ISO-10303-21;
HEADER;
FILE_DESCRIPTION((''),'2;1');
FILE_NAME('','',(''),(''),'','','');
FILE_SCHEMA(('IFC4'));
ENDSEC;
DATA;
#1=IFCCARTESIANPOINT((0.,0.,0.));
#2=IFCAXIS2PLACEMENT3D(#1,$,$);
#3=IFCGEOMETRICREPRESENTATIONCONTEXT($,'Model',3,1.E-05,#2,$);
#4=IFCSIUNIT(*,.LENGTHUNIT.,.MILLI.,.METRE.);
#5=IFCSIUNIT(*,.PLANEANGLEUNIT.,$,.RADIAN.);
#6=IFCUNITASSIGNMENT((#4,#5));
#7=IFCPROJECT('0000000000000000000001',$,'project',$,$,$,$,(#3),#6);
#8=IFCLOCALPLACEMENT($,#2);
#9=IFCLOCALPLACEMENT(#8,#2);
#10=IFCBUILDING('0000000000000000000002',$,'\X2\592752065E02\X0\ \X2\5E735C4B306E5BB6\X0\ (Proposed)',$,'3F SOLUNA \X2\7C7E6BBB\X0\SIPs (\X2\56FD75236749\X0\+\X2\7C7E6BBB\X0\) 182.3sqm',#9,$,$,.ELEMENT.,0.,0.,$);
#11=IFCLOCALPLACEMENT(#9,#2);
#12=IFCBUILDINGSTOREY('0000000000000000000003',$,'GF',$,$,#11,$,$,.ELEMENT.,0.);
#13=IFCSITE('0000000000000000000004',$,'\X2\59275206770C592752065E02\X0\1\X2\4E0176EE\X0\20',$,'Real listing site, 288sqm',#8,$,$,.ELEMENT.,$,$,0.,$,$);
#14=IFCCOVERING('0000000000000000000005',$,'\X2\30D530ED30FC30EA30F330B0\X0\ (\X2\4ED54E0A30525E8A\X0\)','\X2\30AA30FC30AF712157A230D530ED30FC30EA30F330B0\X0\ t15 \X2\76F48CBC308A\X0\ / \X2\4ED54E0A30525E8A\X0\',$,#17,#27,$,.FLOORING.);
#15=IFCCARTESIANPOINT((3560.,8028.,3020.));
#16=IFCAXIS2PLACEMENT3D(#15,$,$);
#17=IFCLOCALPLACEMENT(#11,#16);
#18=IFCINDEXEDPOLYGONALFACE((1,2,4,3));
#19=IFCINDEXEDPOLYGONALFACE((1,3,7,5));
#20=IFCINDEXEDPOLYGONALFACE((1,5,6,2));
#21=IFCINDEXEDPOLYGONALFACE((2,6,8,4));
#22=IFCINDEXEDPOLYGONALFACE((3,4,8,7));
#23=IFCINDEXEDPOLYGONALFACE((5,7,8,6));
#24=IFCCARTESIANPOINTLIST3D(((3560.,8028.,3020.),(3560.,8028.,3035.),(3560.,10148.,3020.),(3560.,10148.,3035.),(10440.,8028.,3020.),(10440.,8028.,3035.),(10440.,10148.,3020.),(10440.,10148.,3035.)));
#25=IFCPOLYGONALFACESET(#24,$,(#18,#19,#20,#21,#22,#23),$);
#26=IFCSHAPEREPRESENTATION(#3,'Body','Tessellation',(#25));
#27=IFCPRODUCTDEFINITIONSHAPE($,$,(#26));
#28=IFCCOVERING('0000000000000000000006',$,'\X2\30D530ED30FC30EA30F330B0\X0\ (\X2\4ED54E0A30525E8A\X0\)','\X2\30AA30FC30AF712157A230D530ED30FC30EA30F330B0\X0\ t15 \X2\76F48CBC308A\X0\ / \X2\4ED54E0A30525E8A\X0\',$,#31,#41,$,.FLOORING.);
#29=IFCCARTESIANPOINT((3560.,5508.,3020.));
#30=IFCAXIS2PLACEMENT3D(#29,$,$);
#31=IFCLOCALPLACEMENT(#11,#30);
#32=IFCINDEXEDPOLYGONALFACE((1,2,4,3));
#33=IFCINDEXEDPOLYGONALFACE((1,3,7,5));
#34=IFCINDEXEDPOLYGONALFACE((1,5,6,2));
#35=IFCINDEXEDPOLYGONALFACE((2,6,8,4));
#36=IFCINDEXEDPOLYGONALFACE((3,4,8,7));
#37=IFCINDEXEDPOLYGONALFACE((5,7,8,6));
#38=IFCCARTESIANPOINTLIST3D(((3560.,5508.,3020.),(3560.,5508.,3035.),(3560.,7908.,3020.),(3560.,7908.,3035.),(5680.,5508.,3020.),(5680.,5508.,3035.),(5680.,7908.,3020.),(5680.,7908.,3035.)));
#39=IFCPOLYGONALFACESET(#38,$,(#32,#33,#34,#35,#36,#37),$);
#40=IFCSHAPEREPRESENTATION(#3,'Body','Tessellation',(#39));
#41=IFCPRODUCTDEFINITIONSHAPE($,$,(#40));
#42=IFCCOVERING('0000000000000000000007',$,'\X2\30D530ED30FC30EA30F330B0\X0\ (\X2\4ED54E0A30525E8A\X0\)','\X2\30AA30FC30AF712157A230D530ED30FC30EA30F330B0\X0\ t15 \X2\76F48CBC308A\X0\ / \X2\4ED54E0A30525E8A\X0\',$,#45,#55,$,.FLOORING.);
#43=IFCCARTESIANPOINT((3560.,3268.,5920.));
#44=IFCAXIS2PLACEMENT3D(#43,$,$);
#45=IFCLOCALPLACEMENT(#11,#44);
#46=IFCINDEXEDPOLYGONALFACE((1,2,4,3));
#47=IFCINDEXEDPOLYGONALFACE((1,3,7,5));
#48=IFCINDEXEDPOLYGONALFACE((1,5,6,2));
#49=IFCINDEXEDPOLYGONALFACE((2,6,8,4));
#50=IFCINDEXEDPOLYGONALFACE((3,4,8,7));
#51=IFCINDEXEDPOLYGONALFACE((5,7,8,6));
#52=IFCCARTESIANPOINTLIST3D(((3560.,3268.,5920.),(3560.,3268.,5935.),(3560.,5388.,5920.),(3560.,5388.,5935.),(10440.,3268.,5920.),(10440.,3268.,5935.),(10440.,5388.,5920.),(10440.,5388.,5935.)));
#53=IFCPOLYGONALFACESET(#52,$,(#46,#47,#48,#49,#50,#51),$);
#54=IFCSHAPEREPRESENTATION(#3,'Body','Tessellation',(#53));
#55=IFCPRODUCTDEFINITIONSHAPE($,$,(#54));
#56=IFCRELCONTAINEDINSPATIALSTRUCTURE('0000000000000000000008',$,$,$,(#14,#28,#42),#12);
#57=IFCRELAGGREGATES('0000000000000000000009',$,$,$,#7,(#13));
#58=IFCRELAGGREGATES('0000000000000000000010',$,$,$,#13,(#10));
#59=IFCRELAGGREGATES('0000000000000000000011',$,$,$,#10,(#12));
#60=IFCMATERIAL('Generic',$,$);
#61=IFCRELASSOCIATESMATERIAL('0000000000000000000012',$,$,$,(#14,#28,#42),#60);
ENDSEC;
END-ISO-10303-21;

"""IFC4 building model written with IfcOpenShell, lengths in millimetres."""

from ifc_helpers import new_model, si_unit, frame, frame_2d, origin, place, context, project, spatial, rectangle, extrude, material, element, save


model = new_model("IFC4")

# Units and contexts
model_context = context("Model", 3, precision=1e-05, world=origin())
ifc_project = project(units=[si_unit("LENGTHUNIT", "METRE", prefix="MILLI"), si_unit("PLANEANGLEUNIT", "RADIAN")], contexts=[model_context])

# Site, building, storey
site_placement = place(None, origin())
site = spatial("IfcSite", under=ifc_project, at=site_placement, Name="大分県大分市1丁目20", ObjectType="Real listing site, 288sqm", CompositionType="ELEMENT", RefElevation=0.0)
building_placement = place(site_placement, origin())
building = spatial("IfcBuilding", under=site, at=building_placement, Name="大分市 平屋の家 (Proposed)", ObjectType="3F SOLUNA 籾殻SIPs (国産杉+籾殻) 182.3sqm", CompositionType="ELEMENT", ElevationOfRefHeight=0.0, ElevationOfTerrain=0.0)
storey_placement = place(building_placement, origin())
storey = spatial("IfcBuildingStorey", under=building, at=storey_placement, Name="GF", CompositionType="ELEMENT", Elevation=0.0)

# Shared definitions
ifc_material_1 = material(Name="Generic")

# Coverings
covering_1_placement = place(storey_placement, frame((3560.0, 8028.0, 3020.0)))
element("IfcCovering", 1, at=covering_1_placement, inside=storey, material=ifc_material_1, Name="フローリング (仕上げ床)", Description="オーク無垢フローリング t15 直貼り / 仕上げ床", PredefinedType="FLOORING", context=model_context, shape_type="SweptSolid", body=[
    extrude(rectangle(XDim=6880.0, YDim=2120.0, at=frame_2d((3440.0, 1060.0))), frame((3560.0, 8028.0, 3020.0)), (0.0, 0.0, 1.0), 15.0),
])
covering_2_placement = place(storey_placement, frame((3560.0, 5508.0, 3020.0)))
element("IfcCovering", 2, at=covering_2_placement, inside=storey, material=ifc_material_1, Name="フローリング (仕上げ床)", Description="オーク無垢フローリング t15 直貼り / 仕上げ床", PredefinedType="FLOORING", context=model_context, shape_type="SweptSolid", body=[
    extrude(rectangle(XDim=2120.0, YDim=2400.0, at=frame_2d((1060.0, 1200.0))), frame((3560.0, 5508.0, 3020.0)), (0.0, 0.0, 1.0), 15.0),
])
covering_3_placement = place(storey_placement, frame((3560.0, 3268.0, 5920.0)))
element("IfcCovering", 3, at=covering_3_placement, inside=storey, material=ifc_material_1, Name="フローリング (仕上げ床)", Description="オーク無垢フローリング t15 直貼り / 仕上げ床", PredefinedType="FLOORING", context=model_context, shape_type="SweptSolid", body=[
    extrude(rectangle(XDim=6880.0, YDim=2120.0, at=frame_2d((3440.0, 1060.0))), frame((3560.0, 3268.0, 5920.0)), (0.0, 0.0, 1.0), 15.0),
])

save(model, "model.ifc")
